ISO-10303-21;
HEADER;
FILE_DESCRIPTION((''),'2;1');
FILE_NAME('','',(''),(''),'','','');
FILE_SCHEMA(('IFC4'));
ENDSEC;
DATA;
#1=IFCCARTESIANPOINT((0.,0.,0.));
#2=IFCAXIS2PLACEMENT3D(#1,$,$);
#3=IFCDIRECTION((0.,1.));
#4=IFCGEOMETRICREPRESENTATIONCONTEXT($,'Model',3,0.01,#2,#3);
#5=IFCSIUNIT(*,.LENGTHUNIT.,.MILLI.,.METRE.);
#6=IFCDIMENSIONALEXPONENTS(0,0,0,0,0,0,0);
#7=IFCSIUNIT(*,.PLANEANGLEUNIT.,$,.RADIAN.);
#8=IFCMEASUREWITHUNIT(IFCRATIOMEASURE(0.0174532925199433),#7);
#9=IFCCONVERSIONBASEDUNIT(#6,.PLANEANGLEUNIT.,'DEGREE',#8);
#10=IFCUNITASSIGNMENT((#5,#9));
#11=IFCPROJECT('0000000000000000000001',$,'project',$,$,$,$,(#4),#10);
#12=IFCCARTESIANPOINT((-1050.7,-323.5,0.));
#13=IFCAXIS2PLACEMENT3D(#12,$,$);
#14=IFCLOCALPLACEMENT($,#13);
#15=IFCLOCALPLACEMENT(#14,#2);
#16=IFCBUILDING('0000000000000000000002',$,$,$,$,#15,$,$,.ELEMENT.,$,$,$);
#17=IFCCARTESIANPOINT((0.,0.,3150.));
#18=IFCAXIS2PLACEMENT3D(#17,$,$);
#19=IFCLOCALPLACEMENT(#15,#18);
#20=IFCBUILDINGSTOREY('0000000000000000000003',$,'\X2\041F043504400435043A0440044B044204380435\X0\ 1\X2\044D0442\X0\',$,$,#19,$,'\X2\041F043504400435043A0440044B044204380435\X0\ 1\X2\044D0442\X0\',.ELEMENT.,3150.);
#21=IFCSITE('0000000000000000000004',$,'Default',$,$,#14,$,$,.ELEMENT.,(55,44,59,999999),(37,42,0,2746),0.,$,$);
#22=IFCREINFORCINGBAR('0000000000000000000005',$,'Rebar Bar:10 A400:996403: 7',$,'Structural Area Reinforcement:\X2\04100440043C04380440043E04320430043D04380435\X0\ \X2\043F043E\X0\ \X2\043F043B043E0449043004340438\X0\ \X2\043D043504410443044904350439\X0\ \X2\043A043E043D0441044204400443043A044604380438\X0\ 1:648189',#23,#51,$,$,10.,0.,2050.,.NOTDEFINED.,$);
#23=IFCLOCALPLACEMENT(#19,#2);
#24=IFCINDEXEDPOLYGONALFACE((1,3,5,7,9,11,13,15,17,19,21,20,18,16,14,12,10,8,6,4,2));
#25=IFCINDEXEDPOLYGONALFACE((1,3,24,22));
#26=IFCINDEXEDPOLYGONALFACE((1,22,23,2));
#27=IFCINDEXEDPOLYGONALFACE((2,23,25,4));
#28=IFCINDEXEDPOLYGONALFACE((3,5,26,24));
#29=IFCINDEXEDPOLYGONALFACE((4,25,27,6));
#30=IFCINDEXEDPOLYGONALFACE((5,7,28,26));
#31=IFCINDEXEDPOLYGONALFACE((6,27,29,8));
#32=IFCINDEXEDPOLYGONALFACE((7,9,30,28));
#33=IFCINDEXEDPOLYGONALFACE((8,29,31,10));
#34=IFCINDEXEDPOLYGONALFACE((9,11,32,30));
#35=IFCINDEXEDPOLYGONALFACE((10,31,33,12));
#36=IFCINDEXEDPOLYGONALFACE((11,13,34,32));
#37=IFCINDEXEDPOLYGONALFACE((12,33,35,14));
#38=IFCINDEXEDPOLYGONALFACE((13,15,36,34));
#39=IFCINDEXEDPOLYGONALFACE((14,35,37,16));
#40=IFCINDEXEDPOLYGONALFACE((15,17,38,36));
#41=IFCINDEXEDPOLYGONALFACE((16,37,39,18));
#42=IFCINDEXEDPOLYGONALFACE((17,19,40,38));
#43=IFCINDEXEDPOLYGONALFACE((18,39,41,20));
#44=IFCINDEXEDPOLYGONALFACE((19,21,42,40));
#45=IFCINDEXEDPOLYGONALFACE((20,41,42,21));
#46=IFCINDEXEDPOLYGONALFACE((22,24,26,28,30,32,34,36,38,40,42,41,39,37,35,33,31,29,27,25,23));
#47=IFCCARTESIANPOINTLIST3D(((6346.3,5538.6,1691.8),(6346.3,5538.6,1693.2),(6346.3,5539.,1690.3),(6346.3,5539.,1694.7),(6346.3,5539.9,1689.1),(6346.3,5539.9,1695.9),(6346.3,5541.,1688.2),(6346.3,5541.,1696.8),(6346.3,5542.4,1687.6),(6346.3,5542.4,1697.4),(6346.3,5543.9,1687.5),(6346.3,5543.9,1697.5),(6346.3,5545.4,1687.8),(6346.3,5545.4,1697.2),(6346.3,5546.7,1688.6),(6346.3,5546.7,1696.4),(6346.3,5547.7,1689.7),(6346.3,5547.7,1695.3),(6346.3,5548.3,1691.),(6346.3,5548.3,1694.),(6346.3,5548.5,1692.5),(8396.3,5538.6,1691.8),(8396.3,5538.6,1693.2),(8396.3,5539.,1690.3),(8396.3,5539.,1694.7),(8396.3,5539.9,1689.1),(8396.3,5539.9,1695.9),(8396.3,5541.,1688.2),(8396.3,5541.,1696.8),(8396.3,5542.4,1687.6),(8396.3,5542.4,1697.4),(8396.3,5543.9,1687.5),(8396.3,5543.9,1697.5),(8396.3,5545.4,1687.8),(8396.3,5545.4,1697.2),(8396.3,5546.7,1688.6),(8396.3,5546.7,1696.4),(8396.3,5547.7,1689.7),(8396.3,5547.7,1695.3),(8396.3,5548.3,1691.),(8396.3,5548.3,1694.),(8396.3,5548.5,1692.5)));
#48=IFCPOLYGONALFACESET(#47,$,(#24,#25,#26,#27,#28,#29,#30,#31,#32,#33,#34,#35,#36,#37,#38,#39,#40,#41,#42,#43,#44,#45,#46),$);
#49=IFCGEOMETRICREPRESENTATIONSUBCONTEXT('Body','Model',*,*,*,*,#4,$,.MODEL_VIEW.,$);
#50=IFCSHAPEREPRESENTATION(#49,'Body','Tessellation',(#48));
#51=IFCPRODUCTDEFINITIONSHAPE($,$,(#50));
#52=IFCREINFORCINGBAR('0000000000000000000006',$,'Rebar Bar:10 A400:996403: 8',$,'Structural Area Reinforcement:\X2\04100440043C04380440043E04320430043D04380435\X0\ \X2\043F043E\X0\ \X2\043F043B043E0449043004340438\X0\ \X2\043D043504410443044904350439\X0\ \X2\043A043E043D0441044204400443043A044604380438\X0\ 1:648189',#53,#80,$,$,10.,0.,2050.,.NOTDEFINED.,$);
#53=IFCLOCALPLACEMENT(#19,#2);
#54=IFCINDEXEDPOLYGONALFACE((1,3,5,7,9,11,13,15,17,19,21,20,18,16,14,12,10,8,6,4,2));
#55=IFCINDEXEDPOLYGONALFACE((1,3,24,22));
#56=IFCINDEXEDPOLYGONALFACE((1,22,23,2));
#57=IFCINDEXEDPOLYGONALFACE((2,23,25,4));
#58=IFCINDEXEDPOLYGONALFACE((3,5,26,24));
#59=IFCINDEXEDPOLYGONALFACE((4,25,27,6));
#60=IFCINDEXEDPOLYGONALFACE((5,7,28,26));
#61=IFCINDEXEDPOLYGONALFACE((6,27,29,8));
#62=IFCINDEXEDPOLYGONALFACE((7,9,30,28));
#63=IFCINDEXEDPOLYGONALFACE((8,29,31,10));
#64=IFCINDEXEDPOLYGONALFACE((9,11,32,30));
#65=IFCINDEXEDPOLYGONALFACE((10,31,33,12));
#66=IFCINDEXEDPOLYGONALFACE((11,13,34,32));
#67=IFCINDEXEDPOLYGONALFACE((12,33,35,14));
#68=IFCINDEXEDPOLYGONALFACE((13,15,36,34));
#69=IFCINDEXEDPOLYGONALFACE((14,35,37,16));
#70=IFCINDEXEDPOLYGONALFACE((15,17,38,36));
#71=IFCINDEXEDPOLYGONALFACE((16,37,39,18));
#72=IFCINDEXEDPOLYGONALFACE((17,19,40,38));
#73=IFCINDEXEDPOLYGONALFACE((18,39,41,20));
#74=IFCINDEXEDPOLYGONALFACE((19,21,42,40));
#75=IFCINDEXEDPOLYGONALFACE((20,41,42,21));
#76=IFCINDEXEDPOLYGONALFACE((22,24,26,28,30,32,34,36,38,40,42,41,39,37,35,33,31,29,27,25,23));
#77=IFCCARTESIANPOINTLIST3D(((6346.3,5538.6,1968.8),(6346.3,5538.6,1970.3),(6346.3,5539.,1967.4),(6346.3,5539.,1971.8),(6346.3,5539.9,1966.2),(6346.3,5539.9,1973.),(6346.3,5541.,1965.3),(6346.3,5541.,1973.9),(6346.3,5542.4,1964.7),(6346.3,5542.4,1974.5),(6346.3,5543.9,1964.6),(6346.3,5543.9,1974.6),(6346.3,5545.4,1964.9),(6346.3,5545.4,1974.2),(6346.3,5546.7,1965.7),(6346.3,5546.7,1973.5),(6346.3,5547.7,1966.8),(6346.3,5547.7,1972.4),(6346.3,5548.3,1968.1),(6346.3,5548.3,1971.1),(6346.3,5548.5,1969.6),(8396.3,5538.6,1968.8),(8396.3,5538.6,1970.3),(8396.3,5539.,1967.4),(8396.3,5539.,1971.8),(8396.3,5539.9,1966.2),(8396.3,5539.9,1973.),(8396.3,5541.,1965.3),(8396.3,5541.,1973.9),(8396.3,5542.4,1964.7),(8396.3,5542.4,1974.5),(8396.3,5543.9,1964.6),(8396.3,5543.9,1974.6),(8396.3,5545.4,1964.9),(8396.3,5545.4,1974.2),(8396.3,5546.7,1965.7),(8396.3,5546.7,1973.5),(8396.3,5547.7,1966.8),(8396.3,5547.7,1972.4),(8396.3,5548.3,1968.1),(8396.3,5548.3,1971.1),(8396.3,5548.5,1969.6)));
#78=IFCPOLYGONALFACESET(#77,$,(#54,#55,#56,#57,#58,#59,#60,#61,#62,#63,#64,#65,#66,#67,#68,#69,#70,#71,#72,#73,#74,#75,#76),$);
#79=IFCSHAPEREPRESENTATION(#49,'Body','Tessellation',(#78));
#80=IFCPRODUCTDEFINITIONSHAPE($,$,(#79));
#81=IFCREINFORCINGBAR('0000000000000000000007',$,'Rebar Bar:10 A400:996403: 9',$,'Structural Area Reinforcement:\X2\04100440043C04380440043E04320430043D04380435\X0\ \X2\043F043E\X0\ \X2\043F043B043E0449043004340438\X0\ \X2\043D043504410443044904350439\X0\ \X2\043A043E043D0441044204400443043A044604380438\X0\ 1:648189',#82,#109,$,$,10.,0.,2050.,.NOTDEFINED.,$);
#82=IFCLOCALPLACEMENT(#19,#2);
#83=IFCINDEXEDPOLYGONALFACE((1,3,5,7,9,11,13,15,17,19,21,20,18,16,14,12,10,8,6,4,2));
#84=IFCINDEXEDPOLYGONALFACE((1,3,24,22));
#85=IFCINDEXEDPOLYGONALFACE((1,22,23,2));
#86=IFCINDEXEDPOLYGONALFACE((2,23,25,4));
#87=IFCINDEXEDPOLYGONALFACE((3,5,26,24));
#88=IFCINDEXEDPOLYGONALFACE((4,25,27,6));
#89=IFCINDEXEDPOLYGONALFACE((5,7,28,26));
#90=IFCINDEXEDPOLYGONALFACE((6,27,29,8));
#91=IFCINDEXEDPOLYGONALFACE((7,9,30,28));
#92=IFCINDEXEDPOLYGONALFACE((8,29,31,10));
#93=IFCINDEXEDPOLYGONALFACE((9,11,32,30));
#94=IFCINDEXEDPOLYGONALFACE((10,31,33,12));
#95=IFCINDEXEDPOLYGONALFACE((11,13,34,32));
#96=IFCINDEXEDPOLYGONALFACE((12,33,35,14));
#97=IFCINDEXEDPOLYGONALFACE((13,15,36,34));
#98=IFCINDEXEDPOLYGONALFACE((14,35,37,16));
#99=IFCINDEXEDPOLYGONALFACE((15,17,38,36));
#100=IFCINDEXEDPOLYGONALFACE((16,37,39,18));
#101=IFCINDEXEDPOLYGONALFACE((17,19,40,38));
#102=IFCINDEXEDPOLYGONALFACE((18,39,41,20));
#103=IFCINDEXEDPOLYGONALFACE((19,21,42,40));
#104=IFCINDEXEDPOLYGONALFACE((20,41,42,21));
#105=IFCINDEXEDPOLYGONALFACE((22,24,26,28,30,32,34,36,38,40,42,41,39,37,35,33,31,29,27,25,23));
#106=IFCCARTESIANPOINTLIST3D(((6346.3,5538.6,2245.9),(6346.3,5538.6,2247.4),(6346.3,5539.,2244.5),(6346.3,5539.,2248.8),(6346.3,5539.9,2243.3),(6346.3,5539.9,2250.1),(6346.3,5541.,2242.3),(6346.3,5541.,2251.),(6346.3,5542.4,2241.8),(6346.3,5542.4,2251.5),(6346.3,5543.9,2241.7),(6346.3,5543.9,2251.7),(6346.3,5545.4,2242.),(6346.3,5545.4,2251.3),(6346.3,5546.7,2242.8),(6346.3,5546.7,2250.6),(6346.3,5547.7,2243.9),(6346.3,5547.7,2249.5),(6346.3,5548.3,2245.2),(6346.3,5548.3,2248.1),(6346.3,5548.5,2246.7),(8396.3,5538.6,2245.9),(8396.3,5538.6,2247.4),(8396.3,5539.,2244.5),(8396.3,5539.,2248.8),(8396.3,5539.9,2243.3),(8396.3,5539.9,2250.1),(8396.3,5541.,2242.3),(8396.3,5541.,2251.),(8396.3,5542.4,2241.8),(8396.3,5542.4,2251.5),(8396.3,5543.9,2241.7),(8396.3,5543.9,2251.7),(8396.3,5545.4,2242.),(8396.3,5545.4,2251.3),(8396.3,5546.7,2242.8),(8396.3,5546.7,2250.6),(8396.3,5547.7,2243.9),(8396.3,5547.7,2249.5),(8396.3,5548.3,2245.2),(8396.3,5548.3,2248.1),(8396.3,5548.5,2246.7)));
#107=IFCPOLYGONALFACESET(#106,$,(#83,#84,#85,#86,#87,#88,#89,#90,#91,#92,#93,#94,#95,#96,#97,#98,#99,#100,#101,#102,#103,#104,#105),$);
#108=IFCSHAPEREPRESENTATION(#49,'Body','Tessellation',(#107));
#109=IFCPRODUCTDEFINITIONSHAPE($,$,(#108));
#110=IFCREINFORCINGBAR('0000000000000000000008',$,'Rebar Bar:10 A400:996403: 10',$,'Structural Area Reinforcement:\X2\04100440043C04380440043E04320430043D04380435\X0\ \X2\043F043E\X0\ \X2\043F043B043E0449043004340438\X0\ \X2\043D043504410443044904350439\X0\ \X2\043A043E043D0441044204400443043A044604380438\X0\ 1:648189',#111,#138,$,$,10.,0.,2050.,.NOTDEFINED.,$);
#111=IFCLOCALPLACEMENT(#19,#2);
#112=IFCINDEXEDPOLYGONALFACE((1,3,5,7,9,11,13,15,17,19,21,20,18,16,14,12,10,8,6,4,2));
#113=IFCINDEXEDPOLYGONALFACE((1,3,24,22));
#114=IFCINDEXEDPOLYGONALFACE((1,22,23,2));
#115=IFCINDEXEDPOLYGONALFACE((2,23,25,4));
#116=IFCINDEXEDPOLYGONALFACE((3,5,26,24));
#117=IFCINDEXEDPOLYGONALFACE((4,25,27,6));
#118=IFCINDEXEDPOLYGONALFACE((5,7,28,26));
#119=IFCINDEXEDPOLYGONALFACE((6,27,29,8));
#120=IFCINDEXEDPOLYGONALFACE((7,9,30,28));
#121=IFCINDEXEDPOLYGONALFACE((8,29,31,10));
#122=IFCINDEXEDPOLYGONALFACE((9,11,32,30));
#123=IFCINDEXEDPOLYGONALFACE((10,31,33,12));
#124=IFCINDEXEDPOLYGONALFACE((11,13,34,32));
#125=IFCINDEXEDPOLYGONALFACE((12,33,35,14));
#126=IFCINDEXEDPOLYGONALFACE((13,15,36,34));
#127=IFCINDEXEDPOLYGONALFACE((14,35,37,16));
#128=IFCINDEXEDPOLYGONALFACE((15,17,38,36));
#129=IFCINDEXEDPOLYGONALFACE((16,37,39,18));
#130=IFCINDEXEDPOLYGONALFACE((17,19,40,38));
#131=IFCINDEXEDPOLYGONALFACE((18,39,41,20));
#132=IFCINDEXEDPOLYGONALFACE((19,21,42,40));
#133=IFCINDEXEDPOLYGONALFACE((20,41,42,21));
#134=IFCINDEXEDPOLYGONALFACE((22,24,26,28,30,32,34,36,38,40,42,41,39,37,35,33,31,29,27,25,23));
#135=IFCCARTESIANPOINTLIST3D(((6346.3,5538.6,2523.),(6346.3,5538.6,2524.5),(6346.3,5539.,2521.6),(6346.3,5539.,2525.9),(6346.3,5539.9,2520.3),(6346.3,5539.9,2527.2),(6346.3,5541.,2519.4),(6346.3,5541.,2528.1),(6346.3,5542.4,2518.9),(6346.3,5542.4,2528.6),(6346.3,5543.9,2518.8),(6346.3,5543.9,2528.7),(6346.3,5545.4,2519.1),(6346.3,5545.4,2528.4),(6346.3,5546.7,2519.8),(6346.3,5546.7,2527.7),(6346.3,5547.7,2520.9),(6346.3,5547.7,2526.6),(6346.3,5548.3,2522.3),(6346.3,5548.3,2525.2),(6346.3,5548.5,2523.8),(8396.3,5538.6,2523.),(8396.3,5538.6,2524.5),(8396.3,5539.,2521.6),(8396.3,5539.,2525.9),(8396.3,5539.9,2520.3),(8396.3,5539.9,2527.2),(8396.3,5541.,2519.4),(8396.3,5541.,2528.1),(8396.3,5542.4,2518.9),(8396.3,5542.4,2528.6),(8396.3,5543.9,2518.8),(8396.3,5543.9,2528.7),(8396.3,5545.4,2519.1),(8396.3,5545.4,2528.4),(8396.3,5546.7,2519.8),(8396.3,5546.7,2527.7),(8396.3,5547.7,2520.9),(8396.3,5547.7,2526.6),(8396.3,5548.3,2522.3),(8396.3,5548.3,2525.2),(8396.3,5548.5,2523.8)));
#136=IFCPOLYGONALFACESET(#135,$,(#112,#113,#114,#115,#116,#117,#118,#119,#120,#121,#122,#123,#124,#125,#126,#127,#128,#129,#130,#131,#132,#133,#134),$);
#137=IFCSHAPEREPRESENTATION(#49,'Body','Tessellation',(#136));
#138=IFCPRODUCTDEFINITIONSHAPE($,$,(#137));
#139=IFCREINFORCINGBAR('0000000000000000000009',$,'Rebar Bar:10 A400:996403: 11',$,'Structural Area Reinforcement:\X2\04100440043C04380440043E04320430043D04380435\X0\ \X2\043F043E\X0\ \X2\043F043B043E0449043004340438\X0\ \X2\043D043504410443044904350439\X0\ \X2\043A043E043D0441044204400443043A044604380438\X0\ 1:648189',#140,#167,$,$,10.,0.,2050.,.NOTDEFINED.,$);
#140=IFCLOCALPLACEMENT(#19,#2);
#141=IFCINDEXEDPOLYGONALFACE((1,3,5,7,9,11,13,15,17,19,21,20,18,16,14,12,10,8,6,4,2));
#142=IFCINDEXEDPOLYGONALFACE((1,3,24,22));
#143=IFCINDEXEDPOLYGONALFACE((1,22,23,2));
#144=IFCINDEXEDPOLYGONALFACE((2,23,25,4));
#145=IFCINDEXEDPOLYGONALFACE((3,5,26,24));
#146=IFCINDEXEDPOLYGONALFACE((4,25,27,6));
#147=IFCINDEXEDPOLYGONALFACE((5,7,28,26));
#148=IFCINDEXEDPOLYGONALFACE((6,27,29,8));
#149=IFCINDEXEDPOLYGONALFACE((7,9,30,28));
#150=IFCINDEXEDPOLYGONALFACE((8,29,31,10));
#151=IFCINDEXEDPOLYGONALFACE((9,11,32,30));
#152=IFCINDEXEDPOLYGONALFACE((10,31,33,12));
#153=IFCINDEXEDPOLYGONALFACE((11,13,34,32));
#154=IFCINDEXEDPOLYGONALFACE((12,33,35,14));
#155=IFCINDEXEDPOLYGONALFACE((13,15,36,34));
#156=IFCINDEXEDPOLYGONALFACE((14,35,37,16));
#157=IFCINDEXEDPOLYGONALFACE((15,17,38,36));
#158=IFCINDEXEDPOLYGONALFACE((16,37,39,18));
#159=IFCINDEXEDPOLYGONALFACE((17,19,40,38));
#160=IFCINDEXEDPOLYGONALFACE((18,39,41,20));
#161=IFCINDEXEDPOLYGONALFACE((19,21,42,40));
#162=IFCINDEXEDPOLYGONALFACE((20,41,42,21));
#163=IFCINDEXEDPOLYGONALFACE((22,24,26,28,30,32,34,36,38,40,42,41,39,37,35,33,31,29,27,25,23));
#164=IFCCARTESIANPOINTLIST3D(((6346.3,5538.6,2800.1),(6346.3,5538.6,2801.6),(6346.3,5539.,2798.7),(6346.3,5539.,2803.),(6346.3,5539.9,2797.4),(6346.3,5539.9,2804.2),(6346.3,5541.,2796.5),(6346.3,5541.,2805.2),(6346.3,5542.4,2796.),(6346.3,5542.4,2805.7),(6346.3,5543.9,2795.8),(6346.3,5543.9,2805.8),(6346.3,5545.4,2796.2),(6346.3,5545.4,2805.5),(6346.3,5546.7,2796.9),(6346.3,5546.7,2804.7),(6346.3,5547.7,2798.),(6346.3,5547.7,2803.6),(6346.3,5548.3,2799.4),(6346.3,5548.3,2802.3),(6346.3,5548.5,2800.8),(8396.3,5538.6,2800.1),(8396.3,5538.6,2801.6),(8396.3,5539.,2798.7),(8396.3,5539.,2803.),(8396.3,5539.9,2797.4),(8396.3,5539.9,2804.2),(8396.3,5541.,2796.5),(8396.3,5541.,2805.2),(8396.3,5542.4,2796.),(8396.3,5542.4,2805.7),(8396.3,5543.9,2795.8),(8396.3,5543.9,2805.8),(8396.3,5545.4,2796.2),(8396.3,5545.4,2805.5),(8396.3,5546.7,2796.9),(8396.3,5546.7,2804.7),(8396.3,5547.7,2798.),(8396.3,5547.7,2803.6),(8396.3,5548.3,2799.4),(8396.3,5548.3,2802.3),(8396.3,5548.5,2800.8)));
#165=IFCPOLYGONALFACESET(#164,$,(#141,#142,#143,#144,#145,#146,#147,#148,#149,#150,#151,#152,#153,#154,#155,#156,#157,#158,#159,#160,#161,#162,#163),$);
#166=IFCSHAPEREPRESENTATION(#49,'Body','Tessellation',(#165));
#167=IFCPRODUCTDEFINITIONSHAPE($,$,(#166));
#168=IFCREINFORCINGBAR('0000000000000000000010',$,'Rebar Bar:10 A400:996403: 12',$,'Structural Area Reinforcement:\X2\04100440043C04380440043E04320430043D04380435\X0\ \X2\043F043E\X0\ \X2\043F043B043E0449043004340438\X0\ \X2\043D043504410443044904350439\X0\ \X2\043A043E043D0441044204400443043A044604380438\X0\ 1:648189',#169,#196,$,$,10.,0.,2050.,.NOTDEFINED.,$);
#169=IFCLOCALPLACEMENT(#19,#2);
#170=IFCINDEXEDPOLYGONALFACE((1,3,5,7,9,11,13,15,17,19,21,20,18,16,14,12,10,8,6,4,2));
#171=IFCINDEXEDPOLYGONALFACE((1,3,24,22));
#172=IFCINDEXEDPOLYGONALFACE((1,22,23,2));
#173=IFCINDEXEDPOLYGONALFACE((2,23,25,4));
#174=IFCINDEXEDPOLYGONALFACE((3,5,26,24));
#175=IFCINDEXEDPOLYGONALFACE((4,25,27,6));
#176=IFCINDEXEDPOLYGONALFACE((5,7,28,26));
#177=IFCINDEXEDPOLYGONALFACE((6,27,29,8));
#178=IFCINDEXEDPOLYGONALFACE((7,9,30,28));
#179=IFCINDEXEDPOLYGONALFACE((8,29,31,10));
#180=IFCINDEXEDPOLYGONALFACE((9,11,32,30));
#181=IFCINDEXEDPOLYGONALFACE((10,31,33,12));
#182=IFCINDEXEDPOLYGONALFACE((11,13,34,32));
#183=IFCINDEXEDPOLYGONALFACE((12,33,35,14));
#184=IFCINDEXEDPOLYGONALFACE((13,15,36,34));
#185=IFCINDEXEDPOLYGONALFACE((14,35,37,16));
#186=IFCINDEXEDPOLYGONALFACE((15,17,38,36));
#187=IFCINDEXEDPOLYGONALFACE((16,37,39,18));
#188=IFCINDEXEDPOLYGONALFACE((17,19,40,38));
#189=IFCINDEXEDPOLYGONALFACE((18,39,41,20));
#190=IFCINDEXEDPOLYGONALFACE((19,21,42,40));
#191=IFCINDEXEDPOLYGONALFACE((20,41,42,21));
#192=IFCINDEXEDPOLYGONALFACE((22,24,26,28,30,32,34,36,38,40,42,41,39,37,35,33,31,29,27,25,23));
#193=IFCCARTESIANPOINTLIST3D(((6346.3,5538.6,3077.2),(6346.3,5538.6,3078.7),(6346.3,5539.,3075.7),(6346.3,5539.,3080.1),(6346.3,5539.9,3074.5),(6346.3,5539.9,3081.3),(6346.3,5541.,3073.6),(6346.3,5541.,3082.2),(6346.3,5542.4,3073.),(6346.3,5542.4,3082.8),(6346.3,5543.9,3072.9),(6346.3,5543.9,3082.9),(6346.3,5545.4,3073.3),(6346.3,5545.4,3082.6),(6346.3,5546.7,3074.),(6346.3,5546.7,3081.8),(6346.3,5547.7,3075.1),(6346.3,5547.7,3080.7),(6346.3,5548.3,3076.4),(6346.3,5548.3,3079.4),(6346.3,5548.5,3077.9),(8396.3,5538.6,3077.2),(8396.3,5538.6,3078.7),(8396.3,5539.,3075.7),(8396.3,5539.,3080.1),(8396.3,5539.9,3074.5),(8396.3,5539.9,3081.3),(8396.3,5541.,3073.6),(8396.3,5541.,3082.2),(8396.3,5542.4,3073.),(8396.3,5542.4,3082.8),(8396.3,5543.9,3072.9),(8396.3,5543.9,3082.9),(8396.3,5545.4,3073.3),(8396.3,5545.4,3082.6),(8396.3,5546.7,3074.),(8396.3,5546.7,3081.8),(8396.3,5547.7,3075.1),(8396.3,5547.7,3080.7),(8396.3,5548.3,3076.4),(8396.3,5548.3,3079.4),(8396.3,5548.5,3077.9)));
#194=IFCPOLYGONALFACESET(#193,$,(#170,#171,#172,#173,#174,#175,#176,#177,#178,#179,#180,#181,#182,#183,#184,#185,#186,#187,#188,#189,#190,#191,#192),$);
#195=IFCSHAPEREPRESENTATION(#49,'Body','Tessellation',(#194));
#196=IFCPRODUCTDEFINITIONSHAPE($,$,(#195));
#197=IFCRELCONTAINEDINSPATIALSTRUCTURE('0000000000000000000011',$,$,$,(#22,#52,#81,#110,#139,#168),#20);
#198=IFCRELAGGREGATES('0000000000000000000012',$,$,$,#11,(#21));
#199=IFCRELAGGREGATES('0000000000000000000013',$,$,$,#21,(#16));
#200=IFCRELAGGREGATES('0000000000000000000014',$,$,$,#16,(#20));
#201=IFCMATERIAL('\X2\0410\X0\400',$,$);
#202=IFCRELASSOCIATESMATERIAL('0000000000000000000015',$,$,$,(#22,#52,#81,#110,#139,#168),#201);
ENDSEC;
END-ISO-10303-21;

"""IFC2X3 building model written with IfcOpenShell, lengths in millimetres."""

from ifc_helpers import new_model, entity, si_unit, converted_unit, direction, frame, origin, place, context, subcontext, project, spatial, material, element, save


model = new_model("IFC2X3")

# Units and contexts
model_context = context("Model", 3, precision=0.01, world=origin(), true_north=direction((0.0, 1.0)))
body_context = subcontext(model_context, "Body", "Model", "MODEL_VIEW")
ifc_project = project(units=[si_unit("LENGTHUNIT", "METRE", prefix="MILLI"), converted_unit("PLANEANGLEUNIT", "DEGREE", entity("IfcRatioMeasure", 0.0174532925199433), si_unit("PLANEANGLEUNIT", "RADIAN"), dimensions=[0, 0, 0, 0, 0, 0, 0])], contexts=[model_context])

# Site, building, storey
site_placement = place(None, frame((-1050.7, -323.5, 0.0)))
site = spatial("IfcSite", under=ifc_project, at=site_placement, Name="Default", CompositionType="ELEMENT", RefLatitude=(55, 44, 59, 999999), RefLongitude=(37, 42, 0, 2746), RefElevation=0.0)
building_placement = place(site_placement, origin())
building = spatial("IfcBuilding", under=site, at=building_placement, CompositionType="ELEMENT")
storey_placement = place(building_placement, frame((0.0, 0.0, 3150.0)))
storey = spatial("IfcBuildingStorey", under=building, at=storey_placement, Name="Перекрытие 1эт", LongName="Перекрытие 1эт", CompositionType="ELEMENT", Elevation=3150.0)

# Reinforcing bars
ifc_material = material(Name="А400")
reinforcing_bar_1_placement = place(storey_placement, origin())
element("IfcReinforcingBar", 1, at=reinforcing_bar_1_placement, inside=storey, material=ifc_material, Name="Rebar Bar:10 A400:996403: 7", ObjectType="Structural Area Reinforcement:Армирование по площади несущей конструкции 1:648189", BarLength=2050.0, BarRole="NOTDEFINED", CrossSectionArea=0.0, NominalDiameter=10.0, context=body_context, shape_type="AdvancedSweptSolid", body=[
    entity("IfcSweptDiskSolid", entity("IfcCompositeCurve", [entity("IfcCompositeCurveSegment", "CONTINUOUS", True, entity("IfcPolyline", [entity("IfcCartesianPoint", [6346.3, 5543.5, 1692.5]), entity("IfcCartesianPoint", [8396.3, 5543.5, 1692.5])]))], False), 5.0, None, 0.0, 1.0),
])
reinforcing_bar_2_placement = place(storey_placement, origin())
element("IfcReinforcingBar", 2, at=reinforcing_bar_2_placement, inside=storey, material=ifc_material, Name="Rebar Bar:10 A400:996403: 8", ObjectType="Structural Area Reinforcement:Армирование по площади несущей конструкции 1:648189", BarLength=2050.0, BarRole="NOTDEFINED", CrossSectionArea=0.0, NominalDiameter=10.0, context=body_context, shape_type="AdvancedSweptSolid", body=[
    entity("IfcSweptDiskSolid", entity("IfcCompositeCurve", [entity("IfcCompositeCurveSegment", "CONTINUOUS", True, entity("IfcPolyline", [entity("IfcCartesianPoint", [6346.3, 5543.5, 1969.6]), entity("IfcCartesianPoint", [8396.3, 5543.5, 1969.6])]))], False), 5.0, None, 0.0, 1.0),
])
reinforcing_bar_3_placement = place(storey_placement, origin())
element("IfcReinforcingBar", 3, at=reinforcing_bar_3_placement, inside=storey, material=ifc_material, Name="Rebar Bar:10 A400:996403: 9", ObjectType="Structural Area Reinforcement:Армирование по площади несущей конструкции 1:648189", BarLength=2050.0, BarRole="NOTDEFINED", CrossSectionArea=0.0, NominalDiameter=10.0, context=body_context, shape_type="AdvancedSweptSolid", body=[
    entity("IfcSweptDiskSolid", entity("IfcCompositeCurve", [entity("IfcCompositeCurveSegment", "CONTINUOUS", True, entity("IfcPolyline", [entity("IfcCartesianPoint", [6346.3, 5543.5, 2246.7]), entity("IfcCartesianPoint", [8396.3, 5543.5, 2246.7])]))], False), 5.0, None, 0.0, 1.0),
])
reinforcing_bar_4_placement = place(storey_placement, origin())
element("IfcReinforcingBar", 4, at=reinforcing_bar_4_placement, inside=storey, material=ifc_material, Name="Rebar Bar:10 A400:996403: 10", ObjectType="Structural Area Reinforcement:Армирование по площади несущей конструкции 1:648189", BarLength=2050.0, BarRole="NOTDEFINED", CrossSectionArea=0.0, NominalDiameter=10.0, context=body_context, shape_type="AdvancedSweptSolid", body=[
    entity("IfcSweptDiskSolid", entity("IfcCompositeCurve", [entity("IfcCompositeCurveSegment", "CONTINUOUS", True, entity("IfcPolyline", [entity("IfcCartesianPoint", [6346.3, 5543.5, 2523.8]), entity("IfcCartesianPoint", [8396.3, 5543.5, 2523.8])]))], False), 5.0, None, 0.0, 1.0),
])
reinforcing_bar_5_placement = place(storey_placement, origin())
element("IfcReinforcingBar", 5, at=reinforcing_bar_5_placement, inside=storey, material=ifc_material, Name="Rebar Bar:10 A400:996403: 11", ObjectType="Structural Area Reinforcement:Армирование по площади несущей конструкции 1:648189", BarLength=2050.0, BarRole="NOTDEFINED", CrossSectionArea=0.0, NominalDiameter=10.0, context=body_context, shape_type="AdvancedSweptSolid", body=[
    entity("IfcSweptDiskSolid", entity("IfcCompositeCurve", [entity("IfcCompositeCurveSegment", "CONTINUOUS", True, entity("IfcPolyline", [entity("IfcCartesianPoint", [6346.3, 5543.5, 2800.8]), entity("IfcCartesianPoint", [8396.3, 5543.5, 2800.8])]))], False), 5.0, None, 0.0, 1.0),
])
reinforcing_bar_6_placement = place(storey_placement, origin())
element("IfcReinforcingBar", 6, at=reinforcing_bar_6_placement, inside=storey, material=ifc_material, Name="Rebar Bar:10 A400:996403: 12", ObjectType="Structural Area Reinforcement:Армирование по площади несущей конструкции 1:648189", BarLength=2050.0, BarRole="NOTDEFINED", CrossSectionArea=0.0, NominalDiameter=10.0, context=body_context, shape_type="AdvancedSweptSolid", body=[
    entity("IfcSweptDiskSolid", entity("IfcCompositeCurve", [entity("IfcCompositeCurveSegment", "CONTINUOUS", True, entity("IfcPolyline", [entity("IfcCartesianPoint", [6346.3, 5543.5, 3077.9]), entity("IfcCartesianPoint", [8396.3, 5543.5, 3077.9])]))], False), 5.0, None, 0.0, 1.0),
])

save(model, "model.ifc")
